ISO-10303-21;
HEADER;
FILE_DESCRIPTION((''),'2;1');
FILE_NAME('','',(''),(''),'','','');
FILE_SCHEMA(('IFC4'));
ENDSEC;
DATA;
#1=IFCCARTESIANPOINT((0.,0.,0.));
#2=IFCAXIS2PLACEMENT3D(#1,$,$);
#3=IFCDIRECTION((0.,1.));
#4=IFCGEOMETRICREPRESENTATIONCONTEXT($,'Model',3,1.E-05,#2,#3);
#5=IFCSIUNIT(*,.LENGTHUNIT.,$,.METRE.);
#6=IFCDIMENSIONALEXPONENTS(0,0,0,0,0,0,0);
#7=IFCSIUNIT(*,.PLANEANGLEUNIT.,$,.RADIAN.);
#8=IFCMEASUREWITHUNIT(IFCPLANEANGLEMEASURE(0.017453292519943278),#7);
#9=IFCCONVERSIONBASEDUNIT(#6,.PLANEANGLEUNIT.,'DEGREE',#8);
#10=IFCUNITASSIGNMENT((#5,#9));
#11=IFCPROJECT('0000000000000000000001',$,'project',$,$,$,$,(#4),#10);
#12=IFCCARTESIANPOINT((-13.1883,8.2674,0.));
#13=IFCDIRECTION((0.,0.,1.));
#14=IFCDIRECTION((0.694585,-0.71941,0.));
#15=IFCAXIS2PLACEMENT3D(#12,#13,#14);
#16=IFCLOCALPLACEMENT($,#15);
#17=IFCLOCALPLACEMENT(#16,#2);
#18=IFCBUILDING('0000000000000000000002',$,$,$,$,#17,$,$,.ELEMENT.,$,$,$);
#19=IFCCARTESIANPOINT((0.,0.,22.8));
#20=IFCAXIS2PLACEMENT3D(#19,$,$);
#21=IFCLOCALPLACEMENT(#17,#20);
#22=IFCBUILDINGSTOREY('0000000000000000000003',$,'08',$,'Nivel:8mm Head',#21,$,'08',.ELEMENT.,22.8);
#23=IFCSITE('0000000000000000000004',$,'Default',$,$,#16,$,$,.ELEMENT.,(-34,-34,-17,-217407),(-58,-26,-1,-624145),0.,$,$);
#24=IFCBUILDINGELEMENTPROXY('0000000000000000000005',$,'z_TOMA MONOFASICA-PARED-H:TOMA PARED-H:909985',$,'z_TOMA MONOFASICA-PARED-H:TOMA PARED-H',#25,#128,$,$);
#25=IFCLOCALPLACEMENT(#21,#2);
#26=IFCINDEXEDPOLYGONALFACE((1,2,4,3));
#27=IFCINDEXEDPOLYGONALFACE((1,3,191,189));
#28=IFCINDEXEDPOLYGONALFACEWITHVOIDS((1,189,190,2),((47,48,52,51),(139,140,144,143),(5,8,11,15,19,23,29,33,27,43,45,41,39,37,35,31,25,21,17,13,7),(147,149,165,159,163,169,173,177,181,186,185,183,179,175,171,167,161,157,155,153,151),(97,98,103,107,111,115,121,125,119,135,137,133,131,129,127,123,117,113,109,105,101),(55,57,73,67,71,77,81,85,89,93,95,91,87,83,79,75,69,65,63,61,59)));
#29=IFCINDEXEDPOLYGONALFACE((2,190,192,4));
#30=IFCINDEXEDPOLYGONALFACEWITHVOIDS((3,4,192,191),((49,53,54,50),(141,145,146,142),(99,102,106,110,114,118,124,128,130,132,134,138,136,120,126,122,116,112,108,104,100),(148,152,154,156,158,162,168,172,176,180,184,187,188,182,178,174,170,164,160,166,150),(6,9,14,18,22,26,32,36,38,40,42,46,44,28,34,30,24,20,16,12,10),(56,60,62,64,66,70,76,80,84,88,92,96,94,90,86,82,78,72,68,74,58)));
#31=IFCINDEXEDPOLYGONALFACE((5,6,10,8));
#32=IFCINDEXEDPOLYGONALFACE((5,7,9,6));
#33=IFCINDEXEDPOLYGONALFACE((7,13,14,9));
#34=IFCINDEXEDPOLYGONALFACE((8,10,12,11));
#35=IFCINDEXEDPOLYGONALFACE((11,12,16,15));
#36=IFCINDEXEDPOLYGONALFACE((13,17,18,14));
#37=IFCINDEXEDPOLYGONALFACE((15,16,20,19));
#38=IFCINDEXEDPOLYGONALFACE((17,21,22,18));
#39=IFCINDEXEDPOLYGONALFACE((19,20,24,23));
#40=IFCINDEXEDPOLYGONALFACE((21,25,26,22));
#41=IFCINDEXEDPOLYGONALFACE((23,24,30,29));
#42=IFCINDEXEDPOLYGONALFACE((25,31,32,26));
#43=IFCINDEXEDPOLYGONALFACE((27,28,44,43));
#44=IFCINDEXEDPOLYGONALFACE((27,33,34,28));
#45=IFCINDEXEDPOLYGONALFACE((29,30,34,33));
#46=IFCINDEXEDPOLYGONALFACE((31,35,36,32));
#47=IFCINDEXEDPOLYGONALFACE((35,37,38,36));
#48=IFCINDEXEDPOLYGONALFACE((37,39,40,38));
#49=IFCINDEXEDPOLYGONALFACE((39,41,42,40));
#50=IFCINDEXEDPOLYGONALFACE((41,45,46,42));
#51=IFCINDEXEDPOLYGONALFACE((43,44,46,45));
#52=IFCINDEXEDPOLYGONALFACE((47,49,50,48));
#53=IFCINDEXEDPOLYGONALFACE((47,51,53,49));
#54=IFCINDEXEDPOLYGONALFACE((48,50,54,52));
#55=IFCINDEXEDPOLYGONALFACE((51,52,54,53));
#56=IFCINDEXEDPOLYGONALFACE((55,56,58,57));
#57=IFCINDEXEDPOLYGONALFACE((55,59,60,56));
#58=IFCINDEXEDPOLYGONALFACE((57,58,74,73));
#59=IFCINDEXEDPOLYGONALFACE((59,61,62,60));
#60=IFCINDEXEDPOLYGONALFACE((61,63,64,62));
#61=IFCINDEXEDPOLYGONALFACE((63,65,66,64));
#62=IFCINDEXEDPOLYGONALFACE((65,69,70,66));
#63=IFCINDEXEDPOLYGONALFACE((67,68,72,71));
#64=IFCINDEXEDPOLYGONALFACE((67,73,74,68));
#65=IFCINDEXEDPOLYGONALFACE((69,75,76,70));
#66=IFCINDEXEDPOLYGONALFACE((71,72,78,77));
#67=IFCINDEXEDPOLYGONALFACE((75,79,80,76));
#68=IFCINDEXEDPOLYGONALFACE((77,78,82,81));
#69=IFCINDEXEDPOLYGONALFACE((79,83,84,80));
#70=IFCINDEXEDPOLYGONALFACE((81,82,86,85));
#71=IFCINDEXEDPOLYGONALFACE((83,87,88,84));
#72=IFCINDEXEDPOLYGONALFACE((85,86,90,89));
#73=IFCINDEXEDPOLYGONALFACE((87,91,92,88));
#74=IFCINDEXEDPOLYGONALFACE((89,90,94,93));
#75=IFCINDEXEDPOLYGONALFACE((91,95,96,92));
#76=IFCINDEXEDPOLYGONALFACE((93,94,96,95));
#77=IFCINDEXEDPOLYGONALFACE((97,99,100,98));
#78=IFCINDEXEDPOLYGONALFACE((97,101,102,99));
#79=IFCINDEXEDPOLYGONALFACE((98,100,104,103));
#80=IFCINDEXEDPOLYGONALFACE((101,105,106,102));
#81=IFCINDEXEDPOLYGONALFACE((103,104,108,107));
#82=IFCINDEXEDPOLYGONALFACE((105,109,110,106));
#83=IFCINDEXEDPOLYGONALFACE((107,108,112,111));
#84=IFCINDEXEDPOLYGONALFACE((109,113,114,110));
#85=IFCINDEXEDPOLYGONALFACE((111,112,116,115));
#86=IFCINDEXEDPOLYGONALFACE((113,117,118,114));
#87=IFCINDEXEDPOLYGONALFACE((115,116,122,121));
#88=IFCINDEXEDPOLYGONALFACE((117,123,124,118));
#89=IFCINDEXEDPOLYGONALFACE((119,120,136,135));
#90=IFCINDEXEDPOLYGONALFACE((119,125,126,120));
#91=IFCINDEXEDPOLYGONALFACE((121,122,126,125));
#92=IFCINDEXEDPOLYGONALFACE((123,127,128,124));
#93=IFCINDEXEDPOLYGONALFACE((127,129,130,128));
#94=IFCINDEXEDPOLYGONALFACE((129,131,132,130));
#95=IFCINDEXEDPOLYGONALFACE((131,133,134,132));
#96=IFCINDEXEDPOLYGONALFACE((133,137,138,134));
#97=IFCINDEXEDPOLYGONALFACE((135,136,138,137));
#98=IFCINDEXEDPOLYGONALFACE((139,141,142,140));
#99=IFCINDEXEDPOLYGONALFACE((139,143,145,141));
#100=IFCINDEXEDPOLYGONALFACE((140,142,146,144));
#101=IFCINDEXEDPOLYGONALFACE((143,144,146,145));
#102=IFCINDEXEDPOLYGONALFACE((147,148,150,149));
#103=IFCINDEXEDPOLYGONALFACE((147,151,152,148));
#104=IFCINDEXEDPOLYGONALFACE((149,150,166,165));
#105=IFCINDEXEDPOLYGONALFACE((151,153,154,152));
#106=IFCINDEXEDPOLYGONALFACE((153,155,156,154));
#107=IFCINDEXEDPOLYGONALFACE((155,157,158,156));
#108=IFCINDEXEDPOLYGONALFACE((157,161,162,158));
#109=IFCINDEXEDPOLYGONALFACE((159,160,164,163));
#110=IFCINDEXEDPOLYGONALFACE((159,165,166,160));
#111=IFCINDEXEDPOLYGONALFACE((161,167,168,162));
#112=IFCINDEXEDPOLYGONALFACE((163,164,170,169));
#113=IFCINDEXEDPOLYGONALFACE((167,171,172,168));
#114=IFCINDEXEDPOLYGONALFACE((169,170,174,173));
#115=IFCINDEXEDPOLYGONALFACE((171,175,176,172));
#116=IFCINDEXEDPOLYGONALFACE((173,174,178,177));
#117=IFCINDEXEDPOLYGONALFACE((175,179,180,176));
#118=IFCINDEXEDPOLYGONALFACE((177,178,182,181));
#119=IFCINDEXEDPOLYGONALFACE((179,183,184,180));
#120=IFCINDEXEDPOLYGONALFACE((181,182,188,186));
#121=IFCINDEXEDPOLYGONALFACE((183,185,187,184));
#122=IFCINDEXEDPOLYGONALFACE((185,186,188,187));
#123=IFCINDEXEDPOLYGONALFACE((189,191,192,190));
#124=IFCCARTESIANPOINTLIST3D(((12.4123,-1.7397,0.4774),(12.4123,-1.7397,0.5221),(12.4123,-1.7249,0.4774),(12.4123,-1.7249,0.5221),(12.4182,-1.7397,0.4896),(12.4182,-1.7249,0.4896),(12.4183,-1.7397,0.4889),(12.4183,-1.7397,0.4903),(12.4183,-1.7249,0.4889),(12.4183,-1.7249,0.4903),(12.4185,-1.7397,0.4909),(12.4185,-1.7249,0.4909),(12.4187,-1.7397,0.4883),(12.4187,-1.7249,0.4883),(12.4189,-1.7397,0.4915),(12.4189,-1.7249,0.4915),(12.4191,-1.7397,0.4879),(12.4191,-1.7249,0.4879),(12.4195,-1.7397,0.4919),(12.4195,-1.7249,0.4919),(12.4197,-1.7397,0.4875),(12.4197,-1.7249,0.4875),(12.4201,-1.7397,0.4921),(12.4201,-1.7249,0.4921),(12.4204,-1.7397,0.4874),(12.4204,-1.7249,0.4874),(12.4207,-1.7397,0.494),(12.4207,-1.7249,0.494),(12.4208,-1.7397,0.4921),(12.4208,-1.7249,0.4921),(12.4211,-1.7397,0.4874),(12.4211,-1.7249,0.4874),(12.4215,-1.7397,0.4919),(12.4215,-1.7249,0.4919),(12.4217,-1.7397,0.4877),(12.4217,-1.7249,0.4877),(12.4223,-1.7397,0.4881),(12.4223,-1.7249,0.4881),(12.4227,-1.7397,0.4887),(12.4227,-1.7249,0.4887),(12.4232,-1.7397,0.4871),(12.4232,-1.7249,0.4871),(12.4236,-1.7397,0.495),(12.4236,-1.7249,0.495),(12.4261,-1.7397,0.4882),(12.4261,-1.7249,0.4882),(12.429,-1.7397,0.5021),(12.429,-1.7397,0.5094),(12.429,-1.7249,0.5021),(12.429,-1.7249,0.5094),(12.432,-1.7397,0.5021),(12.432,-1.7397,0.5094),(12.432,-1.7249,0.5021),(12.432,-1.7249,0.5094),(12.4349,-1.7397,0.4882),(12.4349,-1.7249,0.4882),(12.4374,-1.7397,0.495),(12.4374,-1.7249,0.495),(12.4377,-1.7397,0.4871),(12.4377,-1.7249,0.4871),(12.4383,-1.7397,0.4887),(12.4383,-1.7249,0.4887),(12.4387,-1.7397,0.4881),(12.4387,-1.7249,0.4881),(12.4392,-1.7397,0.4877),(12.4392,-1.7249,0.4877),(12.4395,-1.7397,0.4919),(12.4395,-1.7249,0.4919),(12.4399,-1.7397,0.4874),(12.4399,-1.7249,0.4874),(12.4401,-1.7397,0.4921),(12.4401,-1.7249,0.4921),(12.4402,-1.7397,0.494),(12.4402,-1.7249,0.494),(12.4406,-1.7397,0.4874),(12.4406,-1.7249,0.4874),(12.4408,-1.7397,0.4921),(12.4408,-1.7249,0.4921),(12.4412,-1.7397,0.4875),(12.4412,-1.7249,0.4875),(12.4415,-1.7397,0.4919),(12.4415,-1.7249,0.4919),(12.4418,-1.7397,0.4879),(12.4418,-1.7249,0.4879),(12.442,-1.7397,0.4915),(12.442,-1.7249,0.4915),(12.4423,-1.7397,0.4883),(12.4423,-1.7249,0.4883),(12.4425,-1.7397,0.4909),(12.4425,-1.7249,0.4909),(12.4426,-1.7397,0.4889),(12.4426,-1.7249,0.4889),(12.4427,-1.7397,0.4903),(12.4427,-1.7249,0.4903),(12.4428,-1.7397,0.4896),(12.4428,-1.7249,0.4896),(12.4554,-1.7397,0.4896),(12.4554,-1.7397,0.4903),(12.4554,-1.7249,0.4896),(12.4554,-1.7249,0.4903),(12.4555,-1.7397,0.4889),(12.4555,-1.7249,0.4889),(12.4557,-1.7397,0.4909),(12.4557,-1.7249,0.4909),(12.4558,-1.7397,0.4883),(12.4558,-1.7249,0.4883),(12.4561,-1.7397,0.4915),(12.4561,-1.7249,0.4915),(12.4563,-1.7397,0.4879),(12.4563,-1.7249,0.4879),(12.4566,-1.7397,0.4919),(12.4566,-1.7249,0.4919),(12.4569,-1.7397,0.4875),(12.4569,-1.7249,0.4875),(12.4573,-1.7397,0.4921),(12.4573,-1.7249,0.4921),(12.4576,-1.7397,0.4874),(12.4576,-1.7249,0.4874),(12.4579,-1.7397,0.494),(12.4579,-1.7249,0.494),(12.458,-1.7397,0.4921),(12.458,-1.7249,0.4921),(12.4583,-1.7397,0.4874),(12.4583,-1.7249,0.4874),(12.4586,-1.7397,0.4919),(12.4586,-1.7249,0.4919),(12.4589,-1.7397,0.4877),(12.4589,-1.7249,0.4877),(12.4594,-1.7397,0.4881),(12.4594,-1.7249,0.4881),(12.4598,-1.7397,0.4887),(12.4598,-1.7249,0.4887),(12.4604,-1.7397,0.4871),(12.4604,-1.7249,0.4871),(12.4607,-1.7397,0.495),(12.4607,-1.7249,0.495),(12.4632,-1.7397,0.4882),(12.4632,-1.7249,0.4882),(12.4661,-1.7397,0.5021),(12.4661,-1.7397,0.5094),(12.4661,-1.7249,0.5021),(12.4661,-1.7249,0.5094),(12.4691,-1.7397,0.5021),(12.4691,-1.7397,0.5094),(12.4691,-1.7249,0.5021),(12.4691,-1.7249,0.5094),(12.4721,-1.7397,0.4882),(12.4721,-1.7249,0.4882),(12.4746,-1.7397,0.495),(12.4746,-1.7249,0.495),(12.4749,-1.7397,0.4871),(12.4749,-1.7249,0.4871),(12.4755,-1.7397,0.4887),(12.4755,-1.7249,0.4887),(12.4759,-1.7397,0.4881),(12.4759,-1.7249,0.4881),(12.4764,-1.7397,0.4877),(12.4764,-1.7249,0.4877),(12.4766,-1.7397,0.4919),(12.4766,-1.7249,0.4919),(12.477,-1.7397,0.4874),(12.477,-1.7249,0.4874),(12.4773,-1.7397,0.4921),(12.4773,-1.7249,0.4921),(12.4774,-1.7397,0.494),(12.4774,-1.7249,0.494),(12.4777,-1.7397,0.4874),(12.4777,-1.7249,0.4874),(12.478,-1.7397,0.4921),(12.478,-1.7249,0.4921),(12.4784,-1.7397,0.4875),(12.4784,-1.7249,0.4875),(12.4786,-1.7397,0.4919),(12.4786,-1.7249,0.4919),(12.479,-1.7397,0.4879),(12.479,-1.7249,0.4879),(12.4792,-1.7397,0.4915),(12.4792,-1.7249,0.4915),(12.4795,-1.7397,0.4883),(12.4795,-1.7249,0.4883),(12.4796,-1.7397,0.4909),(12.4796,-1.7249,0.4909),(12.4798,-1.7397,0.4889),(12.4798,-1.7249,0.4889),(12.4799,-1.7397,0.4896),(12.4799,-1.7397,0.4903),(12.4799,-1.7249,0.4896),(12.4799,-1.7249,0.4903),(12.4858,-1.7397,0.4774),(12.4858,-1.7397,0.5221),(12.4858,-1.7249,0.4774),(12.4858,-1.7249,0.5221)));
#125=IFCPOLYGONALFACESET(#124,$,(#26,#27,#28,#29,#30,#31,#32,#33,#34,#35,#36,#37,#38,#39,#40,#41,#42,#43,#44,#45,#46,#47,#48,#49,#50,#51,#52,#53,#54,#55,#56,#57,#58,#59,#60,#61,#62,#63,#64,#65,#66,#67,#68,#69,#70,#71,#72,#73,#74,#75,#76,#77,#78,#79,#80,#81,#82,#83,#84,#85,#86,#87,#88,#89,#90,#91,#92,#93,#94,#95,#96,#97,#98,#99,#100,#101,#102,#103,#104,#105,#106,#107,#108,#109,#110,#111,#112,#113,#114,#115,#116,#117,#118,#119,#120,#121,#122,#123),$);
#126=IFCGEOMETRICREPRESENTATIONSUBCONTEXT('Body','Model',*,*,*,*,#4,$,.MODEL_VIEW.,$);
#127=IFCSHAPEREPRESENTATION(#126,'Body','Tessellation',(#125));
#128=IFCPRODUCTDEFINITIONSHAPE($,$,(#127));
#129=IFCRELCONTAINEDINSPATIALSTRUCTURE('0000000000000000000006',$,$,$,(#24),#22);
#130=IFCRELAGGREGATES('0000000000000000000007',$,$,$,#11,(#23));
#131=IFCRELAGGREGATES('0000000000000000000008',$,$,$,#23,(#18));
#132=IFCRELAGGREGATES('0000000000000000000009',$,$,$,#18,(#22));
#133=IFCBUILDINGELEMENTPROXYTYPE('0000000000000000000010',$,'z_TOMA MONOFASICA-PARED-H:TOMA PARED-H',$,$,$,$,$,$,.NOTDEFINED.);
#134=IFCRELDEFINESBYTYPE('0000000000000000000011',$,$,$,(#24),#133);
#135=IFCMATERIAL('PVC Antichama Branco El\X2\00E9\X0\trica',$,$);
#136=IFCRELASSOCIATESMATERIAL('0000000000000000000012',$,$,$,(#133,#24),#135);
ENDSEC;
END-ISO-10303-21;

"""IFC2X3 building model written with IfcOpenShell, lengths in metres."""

from ifc_helpers import new_model, entity, si_unit, converted_unit, direction, frame, frame_2d, origin, place, context, subcontext, project, spatial, polyline, circle_curve, parameter, trimmed, segment, composite_curve, outline, extrude, source, transform, mapped, material, type_object, type_shapes, element, save


model = new_model("IFC2X3")

# Units and contexts
model_context = context("Model", 3, precision=1e-05, world=origin(), true_north=direction((0.0, 1.0)))
body_context = subcontext(model_context, "Body", "Model", "MODEL_VIEW")
ifc_project = project(units=[si_unit("LENGTHUNIT", "METRE"), converted_unit("PLANEANGLEUNIT", "DEGREE", entity("IfcPlaneAngleMeasure", 0.017453292519943278), si_unit("PLANEANGLEUNIT", "RADIAN"), dimensions=[0, 0, 0, 0, 0, 0, 0])], contexts=[model_context])

# Site, building, storey
site_placement = place(None, frame((-13.1883, 8.2674, 0.0), z_axis=(0.0, 0.0, 1.0), x_axis=(0.694585, -0.71941, 0.0)))
site = spatial("IfcSite", under=ifc_project, at=site_placement, Name="Default", CompositionType="ELEMENT", RefLatitude=(-34, -34, -17, -217407), RefLongitude=(-58, -26, -1, -624145), RefElevation=0.0)
building_placement = place(site_placement, origin())
building = spatial("IfcBuilding", under=site, at=building_placement, CompositionType="ELEMENT")
storey_placement = place(building_placement, frame((0.0, 0.0, 22.8)))
storey = spatial("IfcBuildingStorey", under=building, at=storey_placement, Name="08", ObjectType="Nivel:8mm Head", LongName="08", CompositionType="ELEMENT", Elevation=22.8)

# Building element proxy
ifc_material_1 = material(Name="PVC Antichama Branco Elétrica")
building_element_proxy_type_1 = type_object("IfcBuildingElementProxyType", Name="z_TOMA MONOFASICA-PARED-H:TOMA PARED-H", PredefinedType="NOTDEFINED", material=ifc_material_1)
shared_shape_1 = source(origin(), body_context, "Body", "SweptSolid", [
    extrude(outline(polyline([(-0.0368, -0.0223), (0.0368, -0.0223), (0.0368, 0.0223), (-0.0368, 0.0223), (-0.0368, -0.0223)]), holes=[composite_curve([segment(polyline([(0.0141, 0.0115), (0.0116, 0.0047)]), True, "CONTINUOUS"), segment(polyline([(0.0116, 0.0047), (0.0088, 0.0057)]), True, "CONTINUOUS"), segment(polyline([(0.0088, 0.0057), (0.0096, 0.0078)]), True, "CONTINUOUS"), segment(trimmed(circle_curve(frame_2d((0.0087, 0.0099), x_axis=(1.0, 0.0)), 0.0024), [parameter(27.118901)], [parameter(292.881099)], True, "PARAMETER"), False, "CONTINUOUS"), segment(polyline([(0.0108, 0.011), (0.0113, 0.0126)]), True, "CONTINUOUS"), segment(polyline([(0.0113, 0.0126), (0.0141, 0.0115)]), True, "CONTINUOUS")], self_intersect=False), composite_curve([segment(polyline([(0.0255, 0.0047), (0.023, 0.0115)]), True, "CONTINUOUS"), segment(polyline([(0.023, 0.0115), (0.0258, 0.0126)]), True, "CONTINUOUS"), segment(polyline([(0.0258, 0.0126), (0.0264, 0.011)]), True, "CONTINUOUS"), segment(trimmed(circle_curve(frame_2d((0.0285, 0.0099), x_axis=(1.0, 0.0)), 0.0024), [parameter(247.118901)], [parameter(152.881099)], True, "PARAMETER"), False, "CONTINUOUS"), segment(polyline([(0.0276, 0.0078), (0.0283, 0.0057)]), True, "CONTINUOUS"), segment(polyline([(0.0283, 0.0057), (0.0255, 0.0047)]), True, "CONTINUOUS")], self_intersect=False), polyline([(0.0201, -0.0024), (0.0201, -0.0097), (0.0171, -0.0097), (0.0171, -0.0024), (0.0201, -0.0024)]), composite_curve([segment(polyline([(-0.0141, 0.0115), (-0.0113, 0.0126)]), True, "CONTINUOUS"), segment(polyline([(-0.0113, 0.0126), (-0.0108, 0.011)]), True, "CONTINUOUS"), segment(trimmed(circle_curve(frame_2d((-0.0087, 0.0099), x_axis=(1.0, 0.0)), 0.0024), [parameter(247.118901)], [parameter(152.881099)], True, "PARAMETER"), False, "CONTINUOUS"), segment(polyline([(-0.0096, 0.0078), (-0.0088, 0.0057)]), True, "CONTINUOUS"), segment(polyline([(-0.0088, 0.0057), (-0.0116, 0.0047)]), True, "CONTINUOUS"), segment(polyline([(-0.0116, 0.0047), (-0.0141, 0.0115)]), True, "CONTINUOUS")], self_intersect=False), composite_curve([segment(polyline([(-0.0255, 0.0047), (-0.0283, 0.0057)]), True, "CONTINUOUS"), segment(polyline([(-0.0283, 0.0057), (-0.0276, 0.0078)]), True, "CONTINUOUS"), segment(trimmed(circle_curve(frame_2d((-0.0285, 0.0099), x_axis=(1.0, 0.0)), 0.0024), [parameter(27.118901)], [parameter(292.881099)], True, "PARAMETER"), False, "CONTINUOUS"), segment(polyline([(-0.0264, 0.011), (-0.0258, 0.0126)]), True, "CONTINUOUS"), segment(polyline([(-0.0258, 0.0126), (-0.023, 0.0115)]), True, "CONTINUOUS"), segment(polyline([(-0.023, 0.0115), (-0.0255, 0.0047)]), True, "CONTINUOUS")], self_intersect=False), polyline([(-0.0201, -0.0024), (-0.0171, -0.0024), (-0.0171, -0.0097), (-0.0201, -0.0097), (-0.0201, -0.0024)])]), frame((0.0, -0.005, 0.0223), z_axis=(0.0, 1.0, 0.0), x_axis=(1.0, 0.0, 0.0)), (0.0, 0.0, 1.0), 0.0148),
])
type_shapes(building_element_proxy_type_1, [shared_shape_1])
proxy_1_placement = place(storey_placement, frame((12.4491, -1.7299, 0.4774), z_axis=(0.0, 0.0, 1.0), x_axis=(-1.0, 0.0, 0.0)))
element("IfcBuildingElementProxy", 1, at=proxy_1_placement, inside=storey, type_object=building_element_proxy_type_1, material=ifc_material_1, Name="z_TOMA MONOFASICA-PARED-H:TOMA PARED-H:909985", ObjectType="z_TOMA MONOFASICA-PARED-H:TOMA PARED-H", context=body_context, shape_type="MappedRepresentation", body=[
    mapped(shared_shape_1, transform((0.0, 0.0, 0.0), scale=1.0)),
])

save(model, "model.ifc")
